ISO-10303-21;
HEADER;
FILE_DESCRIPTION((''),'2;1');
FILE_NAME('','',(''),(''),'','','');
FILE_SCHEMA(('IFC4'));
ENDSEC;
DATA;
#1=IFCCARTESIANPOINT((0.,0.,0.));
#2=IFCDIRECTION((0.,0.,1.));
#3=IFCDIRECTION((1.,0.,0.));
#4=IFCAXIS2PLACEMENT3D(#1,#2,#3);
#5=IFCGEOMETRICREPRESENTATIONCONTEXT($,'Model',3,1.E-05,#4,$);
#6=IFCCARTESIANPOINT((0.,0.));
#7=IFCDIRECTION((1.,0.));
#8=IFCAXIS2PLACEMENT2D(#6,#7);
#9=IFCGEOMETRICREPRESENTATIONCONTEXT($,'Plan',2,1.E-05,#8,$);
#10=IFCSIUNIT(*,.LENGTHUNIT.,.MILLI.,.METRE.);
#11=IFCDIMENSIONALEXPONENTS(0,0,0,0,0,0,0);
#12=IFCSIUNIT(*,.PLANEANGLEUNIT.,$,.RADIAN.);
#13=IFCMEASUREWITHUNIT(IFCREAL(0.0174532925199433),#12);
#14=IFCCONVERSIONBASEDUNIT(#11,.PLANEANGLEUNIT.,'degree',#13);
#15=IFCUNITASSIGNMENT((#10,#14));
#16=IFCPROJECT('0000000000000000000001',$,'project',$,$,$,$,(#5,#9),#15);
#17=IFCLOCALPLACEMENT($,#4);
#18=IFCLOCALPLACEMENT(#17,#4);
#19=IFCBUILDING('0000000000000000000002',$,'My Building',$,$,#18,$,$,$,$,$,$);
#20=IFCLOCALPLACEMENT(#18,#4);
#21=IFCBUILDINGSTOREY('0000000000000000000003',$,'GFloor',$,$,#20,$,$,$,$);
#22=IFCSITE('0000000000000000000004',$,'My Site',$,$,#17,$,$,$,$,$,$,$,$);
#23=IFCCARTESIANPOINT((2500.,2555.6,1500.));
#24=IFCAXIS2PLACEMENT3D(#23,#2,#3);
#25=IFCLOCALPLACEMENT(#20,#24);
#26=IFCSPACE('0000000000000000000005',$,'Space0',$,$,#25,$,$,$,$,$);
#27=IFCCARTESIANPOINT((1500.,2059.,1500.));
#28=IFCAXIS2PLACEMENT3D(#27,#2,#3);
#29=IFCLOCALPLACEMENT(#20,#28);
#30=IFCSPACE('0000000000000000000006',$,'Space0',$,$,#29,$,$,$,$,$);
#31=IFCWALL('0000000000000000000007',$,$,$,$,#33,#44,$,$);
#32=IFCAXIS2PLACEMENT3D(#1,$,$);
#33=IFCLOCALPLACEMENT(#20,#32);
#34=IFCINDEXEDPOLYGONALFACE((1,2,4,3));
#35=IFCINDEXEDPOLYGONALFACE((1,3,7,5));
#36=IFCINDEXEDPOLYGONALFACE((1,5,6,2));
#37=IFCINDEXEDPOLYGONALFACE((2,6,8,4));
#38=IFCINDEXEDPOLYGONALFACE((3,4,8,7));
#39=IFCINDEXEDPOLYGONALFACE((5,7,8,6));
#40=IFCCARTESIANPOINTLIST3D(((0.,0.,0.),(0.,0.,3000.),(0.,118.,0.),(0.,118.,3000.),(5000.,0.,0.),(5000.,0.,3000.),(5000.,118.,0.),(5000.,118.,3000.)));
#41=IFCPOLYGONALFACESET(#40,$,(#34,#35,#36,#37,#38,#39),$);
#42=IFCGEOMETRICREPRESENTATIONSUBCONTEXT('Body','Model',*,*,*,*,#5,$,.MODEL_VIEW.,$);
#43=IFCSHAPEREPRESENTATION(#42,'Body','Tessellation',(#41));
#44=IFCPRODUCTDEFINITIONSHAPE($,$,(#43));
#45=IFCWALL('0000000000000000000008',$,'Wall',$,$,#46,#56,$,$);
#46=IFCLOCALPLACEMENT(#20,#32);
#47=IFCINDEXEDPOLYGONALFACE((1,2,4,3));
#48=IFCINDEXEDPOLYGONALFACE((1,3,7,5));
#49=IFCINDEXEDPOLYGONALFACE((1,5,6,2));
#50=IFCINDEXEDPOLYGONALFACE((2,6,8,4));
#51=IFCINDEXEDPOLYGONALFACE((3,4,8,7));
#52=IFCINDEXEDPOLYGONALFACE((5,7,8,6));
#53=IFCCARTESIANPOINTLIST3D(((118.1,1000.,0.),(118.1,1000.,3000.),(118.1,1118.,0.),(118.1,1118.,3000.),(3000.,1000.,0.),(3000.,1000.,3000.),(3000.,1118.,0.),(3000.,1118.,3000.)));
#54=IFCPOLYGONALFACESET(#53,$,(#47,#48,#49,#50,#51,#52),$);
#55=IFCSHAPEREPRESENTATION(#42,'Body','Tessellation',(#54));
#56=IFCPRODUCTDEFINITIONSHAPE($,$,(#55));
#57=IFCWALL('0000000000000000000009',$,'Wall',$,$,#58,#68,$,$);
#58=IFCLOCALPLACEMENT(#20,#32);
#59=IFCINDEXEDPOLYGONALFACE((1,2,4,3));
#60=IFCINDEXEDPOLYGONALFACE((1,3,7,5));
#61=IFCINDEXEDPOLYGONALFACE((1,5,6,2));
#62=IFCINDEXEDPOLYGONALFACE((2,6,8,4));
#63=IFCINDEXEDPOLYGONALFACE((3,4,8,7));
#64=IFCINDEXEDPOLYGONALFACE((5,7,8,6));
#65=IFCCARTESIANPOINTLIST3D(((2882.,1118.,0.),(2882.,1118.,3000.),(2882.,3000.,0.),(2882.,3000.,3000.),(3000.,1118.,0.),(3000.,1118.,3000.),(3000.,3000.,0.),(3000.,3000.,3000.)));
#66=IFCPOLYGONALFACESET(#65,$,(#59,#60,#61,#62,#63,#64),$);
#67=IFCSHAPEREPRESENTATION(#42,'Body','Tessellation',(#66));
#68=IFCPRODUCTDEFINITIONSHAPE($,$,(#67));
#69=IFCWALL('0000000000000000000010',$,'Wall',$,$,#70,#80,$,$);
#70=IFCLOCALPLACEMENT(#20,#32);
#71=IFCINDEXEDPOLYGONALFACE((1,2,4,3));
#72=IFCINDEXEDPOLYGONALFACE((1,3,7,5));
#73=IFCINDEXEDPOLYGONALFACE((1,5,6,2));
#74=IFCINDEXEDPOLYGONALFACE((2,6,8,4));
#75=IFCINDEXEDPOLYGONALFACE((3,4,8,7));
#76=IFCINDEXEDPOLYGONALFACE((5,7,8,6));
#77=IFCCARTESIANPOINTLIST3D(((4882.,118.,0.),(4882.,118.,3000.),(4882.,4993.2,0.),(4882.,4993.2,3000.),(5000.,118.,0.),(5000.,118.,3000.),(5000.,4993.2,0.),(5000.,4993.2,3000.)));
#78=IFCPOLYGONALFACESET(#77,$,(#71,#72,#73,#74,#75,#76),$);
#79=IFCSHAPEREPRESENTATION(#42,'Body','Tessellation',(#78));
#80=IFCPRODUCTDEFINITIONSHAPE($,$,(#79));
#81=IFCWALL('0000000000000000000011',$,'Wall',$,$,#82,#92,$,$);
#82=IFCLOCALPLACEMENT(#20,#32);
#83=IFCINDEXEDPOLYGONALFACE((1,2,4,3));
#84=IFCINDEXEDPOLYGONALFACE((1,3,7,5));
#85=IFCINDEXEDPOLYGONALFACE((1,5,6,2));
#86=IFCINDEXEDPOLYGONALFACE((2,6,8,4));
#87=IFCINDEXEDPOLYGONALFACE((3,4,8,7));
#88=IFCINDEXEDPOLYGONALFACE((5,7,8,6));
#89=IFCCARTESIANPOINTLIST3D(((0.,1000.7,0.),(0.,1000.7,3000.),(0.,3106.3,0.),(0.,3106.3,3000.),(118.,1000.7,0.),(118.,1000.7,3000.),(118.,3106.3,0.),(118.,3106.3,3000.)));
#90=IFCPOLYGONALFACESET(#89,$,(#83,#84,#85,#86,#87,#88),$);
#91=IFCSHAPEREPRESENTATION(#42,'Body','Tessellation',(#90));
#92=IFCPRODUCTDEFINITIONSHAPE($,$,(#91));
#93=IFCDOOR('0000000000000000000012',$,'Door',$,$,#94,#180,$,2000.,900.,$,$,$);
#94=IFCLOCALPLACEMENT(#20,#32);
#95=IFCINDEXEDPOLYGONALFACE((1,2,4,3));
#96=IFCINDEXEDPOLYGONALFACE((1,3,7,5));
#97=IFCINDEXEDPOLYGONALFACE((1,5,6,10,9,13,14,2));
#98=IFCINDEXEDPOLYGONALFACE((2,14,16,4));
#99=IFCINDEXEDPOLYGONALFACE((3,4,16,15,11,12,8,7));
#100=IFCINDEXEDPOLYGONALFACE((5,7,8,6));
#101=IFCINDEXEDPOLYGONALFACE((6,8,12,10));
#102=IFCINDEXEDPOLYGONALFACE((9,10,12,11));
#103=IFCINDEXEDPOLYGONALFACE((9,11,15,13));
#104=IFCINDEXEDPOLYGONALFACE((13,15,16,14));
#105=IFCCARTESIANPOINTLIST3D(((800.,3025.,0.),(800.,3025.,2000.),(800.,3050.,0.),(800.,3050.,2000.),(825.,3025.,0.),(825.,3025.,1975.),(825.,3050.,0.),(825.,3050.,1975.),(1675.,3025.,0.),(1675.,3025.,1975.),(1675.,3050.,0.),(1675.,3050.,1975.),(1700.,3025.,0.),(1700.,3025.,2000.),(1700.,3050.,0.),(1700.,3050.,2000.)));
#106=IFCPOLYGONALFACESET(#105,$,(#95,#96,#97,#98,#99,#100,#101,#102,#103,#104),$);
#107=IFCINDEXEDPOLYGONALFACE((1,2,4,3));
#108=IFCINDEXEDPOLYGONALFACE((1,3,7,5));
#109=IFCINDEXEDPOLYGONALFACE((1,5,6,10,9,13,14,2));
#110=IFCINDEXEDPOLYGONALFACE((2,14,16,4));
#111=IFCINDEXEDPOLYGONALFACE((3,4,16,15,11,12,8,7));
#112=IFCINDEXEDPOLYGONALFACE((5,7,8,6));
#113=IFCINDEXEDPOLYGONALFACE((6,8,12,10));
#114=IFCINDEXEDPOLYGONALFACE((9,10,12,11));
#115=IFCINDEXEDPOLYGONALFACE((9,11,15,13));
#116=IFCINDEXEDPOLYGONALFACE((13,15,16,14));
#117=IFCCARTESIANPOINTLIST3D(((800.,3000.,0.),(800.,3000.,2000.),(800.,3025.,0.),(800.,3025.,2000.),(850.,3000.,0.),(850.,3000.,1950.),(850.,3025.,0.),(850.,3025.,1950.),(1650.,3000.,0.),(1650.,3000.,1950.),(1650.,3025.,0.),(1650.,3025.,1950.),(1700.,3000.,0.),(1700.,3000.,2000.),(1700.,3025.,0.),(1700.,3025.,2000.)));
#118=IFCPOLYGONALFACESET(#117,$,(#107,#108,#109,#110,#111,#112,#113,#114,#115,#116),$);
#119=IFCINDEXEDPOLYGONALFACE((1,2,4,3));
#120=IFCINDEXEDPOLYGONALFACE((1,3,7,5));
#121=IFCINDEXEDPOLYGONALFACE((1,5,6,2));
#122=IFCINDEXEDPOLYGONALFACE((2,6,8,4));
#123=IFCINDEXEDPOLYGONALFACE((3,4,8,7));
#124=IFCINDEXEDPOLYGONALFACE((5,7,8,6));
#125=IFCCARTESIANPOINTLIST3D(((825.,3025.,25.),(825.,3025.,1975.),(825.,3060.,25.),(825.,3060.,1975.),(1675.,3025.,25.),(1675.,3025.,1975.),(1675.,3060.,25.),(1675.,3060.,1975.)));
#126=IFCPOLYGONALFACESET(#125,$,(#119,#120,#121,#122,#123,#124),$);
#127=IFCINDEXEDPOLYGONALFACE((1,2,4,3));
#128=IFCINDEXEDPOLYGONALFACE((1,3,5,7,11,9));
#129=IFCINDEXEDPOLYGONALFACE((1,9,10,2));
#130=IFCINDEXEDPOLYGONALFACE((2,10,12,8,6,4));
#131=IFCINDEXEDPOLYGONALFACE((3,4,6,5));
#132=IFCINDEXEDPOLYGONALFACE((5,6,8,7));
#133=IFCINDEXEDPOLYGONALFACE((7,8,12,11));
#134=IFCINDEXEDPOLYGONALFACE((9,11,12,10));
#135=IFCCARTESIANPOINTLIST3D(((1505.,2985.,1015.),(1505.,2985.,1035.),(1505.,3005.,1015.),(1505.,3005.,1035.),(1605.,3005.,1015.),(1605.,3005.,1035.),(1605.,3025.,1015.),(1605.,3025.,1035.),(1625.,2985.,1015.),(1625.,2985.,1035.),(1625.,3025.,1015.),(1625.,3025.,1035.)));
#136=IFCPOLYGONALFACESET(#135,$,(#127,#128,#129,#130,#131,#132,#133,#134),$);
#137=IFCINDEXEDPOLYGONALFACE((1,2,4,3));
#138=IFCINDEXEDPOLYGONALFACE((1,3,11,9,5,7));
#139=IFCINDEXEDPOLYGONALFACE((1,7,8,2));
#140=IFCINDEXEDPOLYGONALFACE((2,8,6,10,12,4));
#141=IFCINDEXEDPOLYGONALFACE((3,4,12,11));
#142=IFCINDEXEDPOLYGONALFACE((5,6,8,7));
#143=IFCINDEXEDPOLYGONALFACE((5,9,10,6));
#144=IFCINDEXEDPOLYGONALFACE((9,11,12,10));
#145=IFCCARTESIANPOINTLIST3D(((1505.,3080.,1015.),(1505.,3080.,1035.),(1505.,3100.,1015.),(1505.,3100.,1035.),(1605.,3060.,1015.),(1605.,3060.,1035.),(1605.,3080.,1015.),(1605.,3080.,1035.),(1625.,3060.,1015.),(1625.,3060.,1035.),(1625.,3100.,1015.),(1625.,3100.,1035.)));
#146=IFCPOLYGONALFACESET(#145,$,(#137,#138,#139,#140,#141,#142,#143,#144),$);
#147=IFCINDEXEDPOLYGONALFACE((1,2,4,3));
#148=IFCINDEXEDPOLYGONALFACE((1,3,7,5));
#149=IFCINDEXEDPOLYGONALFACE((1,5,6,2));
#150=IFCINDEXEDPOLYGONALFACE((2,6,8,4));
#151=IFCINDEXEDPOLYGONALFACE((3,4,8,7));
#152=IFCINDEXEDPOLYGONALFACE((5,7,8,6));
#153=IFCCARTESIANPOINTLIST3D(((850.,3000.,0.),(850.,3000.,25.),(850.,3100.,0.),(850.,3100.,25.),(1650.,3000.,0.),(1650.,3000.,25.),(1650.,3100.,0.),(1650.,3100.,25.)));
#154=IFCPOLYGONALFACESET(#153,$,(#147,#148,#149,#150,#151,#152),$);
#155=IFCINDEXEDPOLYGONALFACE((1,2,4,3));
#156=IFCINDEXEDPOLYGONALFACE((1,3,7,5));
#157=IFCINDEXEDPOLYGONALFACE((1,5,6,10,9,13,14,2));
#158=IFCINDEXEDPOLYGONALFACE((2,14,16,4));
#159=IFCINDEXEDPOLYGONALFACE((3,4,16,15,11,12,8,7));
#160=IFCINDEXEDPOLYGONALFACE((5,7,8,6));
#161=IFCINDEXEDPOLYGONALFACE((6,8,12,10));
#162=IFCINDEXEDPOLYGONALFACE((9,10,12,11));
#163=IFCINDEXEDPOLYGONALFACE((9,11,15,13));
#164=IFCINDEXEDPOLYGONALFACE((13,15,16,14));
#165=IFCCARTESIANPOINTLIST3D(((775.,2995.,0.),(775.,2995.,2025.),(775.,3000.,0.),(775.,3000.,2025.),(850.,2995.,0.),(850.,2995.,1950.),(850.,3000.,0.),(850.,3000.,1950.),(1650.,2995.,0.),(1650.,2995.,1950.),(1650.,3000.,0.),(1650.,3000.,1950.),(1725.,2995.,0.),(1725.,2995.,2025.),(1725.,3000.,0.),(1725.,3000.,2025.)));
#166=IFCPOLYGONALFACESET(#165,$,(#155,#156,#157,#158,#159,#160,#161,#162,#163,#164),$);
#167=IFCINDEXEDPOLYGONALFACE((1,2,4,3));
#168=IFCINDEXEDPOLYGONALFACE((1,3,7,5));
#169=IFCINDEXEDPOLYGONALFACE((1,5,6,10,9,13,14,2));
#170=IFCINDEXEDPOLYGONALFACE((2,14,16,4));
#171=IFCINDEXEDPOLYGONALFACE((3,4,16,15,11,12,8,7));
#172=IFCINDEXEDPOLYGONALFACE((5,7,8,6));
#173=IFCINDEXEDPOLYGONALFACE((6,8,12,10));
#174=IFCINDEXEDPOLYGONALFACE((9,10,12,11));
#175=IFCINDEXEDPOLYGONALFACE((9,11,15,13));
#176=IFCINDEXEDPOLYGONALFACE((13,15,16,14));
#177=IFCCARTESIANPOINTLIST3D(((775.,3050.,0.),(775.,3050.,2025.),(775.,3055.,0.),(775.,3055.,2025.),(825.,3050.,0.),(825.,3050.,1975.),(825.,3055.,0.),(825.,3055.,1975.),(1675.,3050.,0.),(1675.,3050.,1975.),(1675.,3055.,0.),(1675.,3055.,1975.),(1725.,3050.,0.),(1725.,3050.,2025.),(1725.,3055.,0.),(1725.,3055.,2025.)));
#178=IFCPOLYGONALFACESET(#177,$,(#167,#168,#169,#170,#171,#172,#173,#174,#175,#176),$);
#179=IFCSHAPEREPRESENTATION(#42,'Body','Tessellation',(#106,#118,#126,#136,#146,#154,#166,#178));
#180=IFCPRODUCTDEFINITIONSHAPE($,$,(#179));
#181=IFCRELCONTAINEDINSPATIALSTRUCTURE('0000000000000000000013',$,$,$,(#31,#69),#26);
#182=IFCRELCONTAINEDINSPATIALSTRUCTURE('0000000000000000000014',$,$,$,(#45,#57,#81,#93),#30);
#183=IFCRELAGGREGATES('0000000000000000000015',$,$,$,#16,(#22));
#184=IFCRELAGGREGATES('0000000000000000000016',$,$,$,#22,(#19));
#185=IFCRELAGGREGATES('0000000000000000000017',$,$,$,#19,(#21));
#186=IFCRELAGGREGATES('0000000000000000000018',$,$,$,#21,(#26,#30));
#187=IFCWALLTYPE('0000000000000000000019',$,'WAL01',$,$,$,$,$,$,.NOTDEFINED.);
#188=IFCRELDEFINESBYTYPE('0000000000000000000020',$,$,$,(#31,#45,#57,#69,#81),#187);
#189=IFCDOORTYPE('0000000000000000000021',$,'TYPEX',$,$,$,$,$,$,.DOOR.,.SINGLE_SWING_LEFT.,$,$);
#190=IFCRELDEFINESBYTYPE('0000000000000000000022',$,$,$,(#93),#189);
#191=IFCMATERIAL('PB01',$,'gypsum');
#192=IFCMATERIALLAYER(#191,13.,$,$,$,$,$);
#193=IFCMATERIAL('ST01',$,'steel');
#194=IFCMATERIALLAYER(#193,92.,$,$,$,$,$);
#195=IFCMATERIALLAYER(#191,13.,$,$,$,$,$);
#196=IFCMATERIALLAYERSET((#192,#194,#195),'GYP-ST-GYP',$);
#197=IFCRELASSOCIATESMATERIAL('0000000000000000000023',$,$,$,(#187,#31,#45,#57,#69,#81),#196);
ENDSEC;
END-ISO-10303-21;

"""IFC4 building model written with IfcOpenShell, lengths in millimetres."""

from ifc_helpers import new_model, entity, si_unit, converted_unit, frame, origin_with_axes, origin_2d_with_axis, place, context, subcontext, project, spatial, line, indexed_curve, outline, extrude, shape, source, transform, mapped, material, layer, layer_set, layer_usage, type_object, type_shapes, element, save


model = new_model("IFC4")

# Units and contexts
model_context = context("Model", 3, precision=1e-05, world=origin_with_axes())
plan_context = context("Plan", 2, precision=1e-05, world=origin_2d_with_axis())
body_context_1 = subcontext(model_context, "Body", "Model", "MODEL_VIEW")
body_context_2 = subcontext(plan_context, "Body", "Plan", "PLAN_VIEW")
ifc_project = project(units=[si_unit("LENGTHUNIT", "METRE", prefix="MILLI"), converted_unit("PLANEANGLEUNIT", "degree", entity("IfcReal", 0.0174532925199433), si_unit("PLANEANGLEUNIT", "RADIAN"), dimensions=[0, 0, 0, 0, 0, 0, 0])], contexts=[model_context, plan_context])

# Site, building, storey, space
site_placement = place(None, origin_with_axes())
site = spatial("IfcSite", under=ifc_project, at=site_placement, Name="My Site")
building_placement = place(site_placement, origin_with_axes())
building = spatial("IfcBuilding", under=site, at=building_placement, Name="My Building")
storey_placement = place(building_placement, origin_with_axes())
storey = spatial("IfcBuildingStorey", under=building, at=storey_placement, Name="GFloor")
space_1_placement = place(storey_placement, frame((2500.0, 2555.6, 1500.0), z_axis=(0.0, 0.0, 1.0), x_axis=(1.0, 0.0, 0.0)))
space_1 = spatial("IfcSpace", under=storey, at=space_1_placement, Name="Space0")

# Wall
ifc_material_1 = material(Name="PB01", Category="gypsum")
ifc_layer_1 = layer(ifc_material_1, 13.0)
ifc_material_2 = material(Name="ST01", Category="steel")
ifc_layer_2 = layer(ifc_material_2, 92.0)
ifc_layer_3 = layer(ifc_material_1, 13.0)
ifc_layer_set_1 = layer_set([ifc_layer_1, ifc_layer_2, ifc_layer_3], Name="GYP-ST-GYP")
ifc_layer_usage_1 = layer_usage(ifc_layer_set_1, "AXIS2", "POSITIVE", 0.0)
wall_type_1 = type_object("IfcWallType", Name="WAL01", PredefinedType="NOTDEFINED", material=ifc_layer_set_1)
wall_1_placement = place(space_1_placement, frame((-2500.0, -2555.6, -1500.0), z_axis=(0.0, 0.0, 1.0), x_axis=(1.0, 0.0, 0.0)))
element("IfcWall", 1, at=wall_1_placement, inside=space_1, type_object=wall_type_1, material=ifc_layer_usage_1, context=body_context_1, shape_type="SweptSolid", body=[
    extrude(outline(indexed_curve([(0.0, 0.0), (0.0, 118.0), (5000.0, 118.0), (5000.0, 0.0), (0.0, 0.0)], self_intersect=False)), origin_with_axes(), (0.0, 0.0, 1.0), 3000.0),
])

# Shared definitions
space_2_placement = place(storey_placement, frame((1500.0, 2059.0, 1500.0), z_axis=(0.0, 0.0, 1.0), x_axis=(1.0, 0.0, 0.0)))
space_2 = spatial("IfcSpace", under=storey, at=space_2_placement, Name="Space0")

# Walls
ifc_layer_usage_2 = layer_usage(ifc_layer_set_1, "AXIS2", "POSITIVE", 0.0)
wall_2_placement = place(space_2_placement, frame((-1381.9, -1059.0, -1500.0), z_axis=(0.0, 0.0, 1.0), x_axis=(1.0, 0.0, 0.0)))
element("IfcWall", 2, at=wall_2_placement, inside=space_2, type_object=wall_type_1, material=ifc_layer_usage_2, Name="Wall", context=body_context_1, shape_type="SweptSolid", body=[
    extrude(outline(indexed_curve([(0.0, 0.0), (0.0, 118.0), (2881.9, 118.0), (2881.9, 0.0), (0.0, 0.0)], self_intersect=False)), origin_with_axes(), (0.0, 0.0, 1.0), 3000.0),
])
ifc_layer_usage_3 = layer_usage(ifc_layer_set_1, "AXIS2", "POSITIVE", 0.0)
wall_3_placement = place(space_2_placement, frame((1500.0, -941.0, -1500.0), z_axis=(0.0, 0.0, 1.0), x_axis=(0.0, 1.0, 0.0)))
element("IfcWall", 3, at=wall_3_placement, inside=space_2, type_object=wall_type_1, material=ifc_layer_usage_3, Name="Wall", context=body_context_1, shape_type="SweptSolid", body=[
    extrude(outline(indexed_curve([(0.0, 0.0), (0.0, 118.0), (1882.0, 118.0), (1882.0, 0.0), (0.0, 0.0)], self_intersect=False)), origin_with_axes(), (0.0, 0.0, 1.0), 3000.0),
])
ifc_layer_usage_4 = layer_usage(ifc_layer_set_1, "AXIS2", "POSITIVE", 0.0)
wall_4_placement = place(space_1_placement, frame((2500.0, -2437.6, -1500.0), z_axis=(0.0, 0.0, 1.0), x_axis=(0.0, 1.0, 0.0)))
element("IfcWall", 4, at=wall_4_placement, inside=space_1, type_object=wall_type_1, material=ifc_layer_usage_4, Name="Wall", context=body_context_1, shape_type="SweptSolid", body=[
    extrude(outline(indexed_curve([(0.0, 0.0), (0.0, 118.0), (4875.2, 118.0), (4875.2, 0.0), (0.0, 0.0)], self_intersect=False)), origin_with_axes(), (0.0, 0.0, 1.0), 3000.0),
])
ifc_layer_usage_5 = layer_usage(ifc_layer_set_1, "AXIS2", "POSITIVE", 0.0)
wall_5_placement = place(space_2_placement, frame((-1500.0, 1047.3, -1500.0), z_axis=(0.0, 0.0, 1.0), x_axis=(0.0, -1.0, 0.0)))
element("IfcWall", 5, at=wall_5_placement, inside=space_2, type_object=wall_type_1, material=ifc_layer_usage_5, Name="Wall", context=body_context_1, shape_type="SweptSolid", body=[
    extrude(outline(indexed_curve([(0.0, 0.0), (0.0, 118.0), (2105.6, 118.0), (2105.6, 0.0), (0.0, 0.0)], self_intersect=False)), origin_with_axes(), (0.0, 0.0, 1.0), 3000.0),
])

# Door
door_type = type_object("IfcDoorType", Name="TYPEX", OperationType="SINGLE_SWING_LEFT", PredefinedType="DOOR")
shared_shape_1 = source(origin_with_axes(), body_context_1, "Body", "SweptSolid", [
    extrude(outline(indexed_curve([(0.0, 0.0), (0.0, 2000.0), (900.0, 2000.0), (900.0, 0.0), (875.0, 0.0), (875.0, 1975.0), (25.0, 1975.0), (25.0, 0.0)], segments=[line(1, 2, 3, 4, 5, 6, 7, 8, 1)])), frame((0.0, 25.0, 0.0), z_axis=(0.0, -1.0, 0.0), x_axis=(1.0, 0.0, 0.0)), (0.0, 0.0, -1.0), 25.0),
    extrude(outline(indexed_curve([(0.0, 0.0), (0.0, 2000.0), (900.0, 2000.0), (900.0, 0.0), (850.0, 0.0), (850.0, 1950.0), (50.0, 1950.0), (50.0, 0.0)], segments=[line(1, 2, 3, 4, 5, 6, 7, 8, 1)])), frame((0.0, 0.0, 0.0), z_axis=(0.0, -1.0, 0.0), x_axis=(1.0, 0.0, 0.0)), (0.0, 0.0, -1.0), 25.0),
    extrude(outline(indexed_curve([(0.0, 0.0), (850.0, 0.0), (850.0, 35.0), (0.0, 35.0)], segments=[line(1, 2, 3, 4, 1)])), frame((25.0, 25.0, 25.0), z_axis=(0.0, 0.0, 1.0), x_axis=(1.0, 0.0, 0.0)), (0.0, 0.0, 1.0), 1950.0),
    extrude(outline(indexed_curve([(0.0, 0.0), (0.0, -40.0), (-120.0, -40.0), (-120.0, -20.0), (-20.0, -20.0), (-20.0, 0.0)], segments=[line(1, 2, 3, 4, 5, 6, 1)])), frame((825.0, 25.0, 1015.0), z_axis=(0.0, 0.0, 1.0), x_axis=(1.0, 0.0, 0.0)), (0.0, 0.0, 1.0), 20.0),
    extrude(outline(indexed_curve([(0.0, 0.0), (0.0, 40.0), (-120.0, 40.0), (-120.0, 20.0), (-20.0, 20.0), (-20.0, 0.0)], segments=[line(1, 2, 3, 4, 5, 6, 1)])), frame((825.0, 60.0, 1015.0), z_axis=(0.0, 0.0, 1.0), x_axis=(1.0, 0.0, 0.0)), (0.0, 0.0, 1.0), 20.0),
    extrude(outline(indexed_curve([(0.0, 0.0), (800.0, 0.0), (800.0, 100.0), (0.0, 100.0)], segments=[line(1, 2, 3, 4, 1)])), frame((50.0, 0.0, 0.0), z_axis=(0.0, 0.0, 1.0), x_axis=(1.0, 0.0, 0.0)), (0.0, 0.0, 1.0), 25.0),
    extrude(outline(indexed_curve([(0.0, 0.0), (0.0, 2025.0), (950.0, 2025.0), (950.0, 0.0), (875.0, 0.0), (875.0, 1950.0), (75.0, 1950.0), (75.0, 0.0)], segments=[line(1, 2, 3, 4, 5, 6, 7, 8, 1)])), frame((-25.0, -5.0, 0.0), z_axis=(0.0, -1.0, 0.0), x_axis=(1.0, 0.0, 0.0)), (0.0, 0.0, -1.0), 5.0),
    extrude(outline(indexed_curve([(0.0, 0.0), (0.0, 2025.0), (950.0, 2025.0), (950.0, 0.0), (900.0, 0.0), (900.0, 1975.0), (50.0, 1975.0), (50.0, 0.0)], segments=[line(1, 2, 3, 4, 5, 6, 7, 8, 1)])), frame((-25.0, 50.0, 0.0), z_axis=(0.0, -1.0, 0.0), x_axis=(1.0, 0.0, 0.0)), (0.0, 0.0, -1.0), 5.0),
])
shared_shape_2 = source(origin_with_axes(), body_context_2, "Body", "Curve2D", [
    entity("IfcIndexedPolyCurve", entity("IfcCartesianPointList2D", [[0.0, 0.0], [0.0, 50.0], [25.0, 50.0], [25.0, 25.0], [50.0, 25.0], [50.0, 0.0]]), [entity("IfcLineIndex", [1, 2, 3, 4, 5, 6, 1])]),
    entity("IfcIndexedPolyCurve", entity("IfcCartesianPointList2D", [[900.0, 0.0], [900.0, 50.0], [875.0, 50.0], [875.0, 25.0], [850.0, 25.0], [850.0, 0.0]]), [entity("IfcLineIndex", [1, 2, 3, 4, 5, 6, 1])]),
    entity("IfcTrimmedCurve", entity("IfcEllipse", entity("IfcAxis2Placement2D", entity("IfcCartesianPoint", [60.0, 50.0]), entity("IfcDirection", [1.0, 0.0])), 815.0, 850.0), [entity("IfcCartesianPoint", [875.0, 50.0])], [entity("IfcCartesianPoint", [60.0, 900.0])], True, "CARTESIAN"),
    entity("IfcIndexedPolyCurve", entity("IfcCartesianPointList2D", [[25.0, 50.0], [60.0, 50.0], [60.0, 900.0], [25.0, 900.0]]), [entity("IfcLineIndex", [1, 2, 3, 4, 1])]),
])
type_shapes(door_type, [shared_shape_1, shared_shape_2])
door_placement = place(space_2_placement, frame((-700.0, 941.0, -1500.0), z_axis=(0.0, 0.0, 1.0), x_axis=(1.0, 0.0, 0.0)))
element("IfcDoor", 6, at=door_placement, inside=space_2, type_object=door_type, Name="Door", OverallHeight=2000.0, OverallWidth=900.0, shapes=[
    shape(body_context_1, "Body", "MappedRepresentation", [mapped(shared_shape_1, transform((0.0, 0.0, 0.0), x_axis=(1.0, 0.0, 0.0), y_axis=(0.0, 1.0, 0.0), z_axis=(0.0, 0.0, 1.0), scale=1.0))]),
    shape(body_context_2, "Body", "MappedRepresentation", [mapped(shared_shape_2, transform((0.0, 0.0, 0.0), x_axis=(1.0, 0.0, 0.0), y_axis=(0.0, 1.0, 0.0), z_axis=(0.0, 0.0, 1.0), scale=1.0))]),
])

save(model, "model.ifc")
